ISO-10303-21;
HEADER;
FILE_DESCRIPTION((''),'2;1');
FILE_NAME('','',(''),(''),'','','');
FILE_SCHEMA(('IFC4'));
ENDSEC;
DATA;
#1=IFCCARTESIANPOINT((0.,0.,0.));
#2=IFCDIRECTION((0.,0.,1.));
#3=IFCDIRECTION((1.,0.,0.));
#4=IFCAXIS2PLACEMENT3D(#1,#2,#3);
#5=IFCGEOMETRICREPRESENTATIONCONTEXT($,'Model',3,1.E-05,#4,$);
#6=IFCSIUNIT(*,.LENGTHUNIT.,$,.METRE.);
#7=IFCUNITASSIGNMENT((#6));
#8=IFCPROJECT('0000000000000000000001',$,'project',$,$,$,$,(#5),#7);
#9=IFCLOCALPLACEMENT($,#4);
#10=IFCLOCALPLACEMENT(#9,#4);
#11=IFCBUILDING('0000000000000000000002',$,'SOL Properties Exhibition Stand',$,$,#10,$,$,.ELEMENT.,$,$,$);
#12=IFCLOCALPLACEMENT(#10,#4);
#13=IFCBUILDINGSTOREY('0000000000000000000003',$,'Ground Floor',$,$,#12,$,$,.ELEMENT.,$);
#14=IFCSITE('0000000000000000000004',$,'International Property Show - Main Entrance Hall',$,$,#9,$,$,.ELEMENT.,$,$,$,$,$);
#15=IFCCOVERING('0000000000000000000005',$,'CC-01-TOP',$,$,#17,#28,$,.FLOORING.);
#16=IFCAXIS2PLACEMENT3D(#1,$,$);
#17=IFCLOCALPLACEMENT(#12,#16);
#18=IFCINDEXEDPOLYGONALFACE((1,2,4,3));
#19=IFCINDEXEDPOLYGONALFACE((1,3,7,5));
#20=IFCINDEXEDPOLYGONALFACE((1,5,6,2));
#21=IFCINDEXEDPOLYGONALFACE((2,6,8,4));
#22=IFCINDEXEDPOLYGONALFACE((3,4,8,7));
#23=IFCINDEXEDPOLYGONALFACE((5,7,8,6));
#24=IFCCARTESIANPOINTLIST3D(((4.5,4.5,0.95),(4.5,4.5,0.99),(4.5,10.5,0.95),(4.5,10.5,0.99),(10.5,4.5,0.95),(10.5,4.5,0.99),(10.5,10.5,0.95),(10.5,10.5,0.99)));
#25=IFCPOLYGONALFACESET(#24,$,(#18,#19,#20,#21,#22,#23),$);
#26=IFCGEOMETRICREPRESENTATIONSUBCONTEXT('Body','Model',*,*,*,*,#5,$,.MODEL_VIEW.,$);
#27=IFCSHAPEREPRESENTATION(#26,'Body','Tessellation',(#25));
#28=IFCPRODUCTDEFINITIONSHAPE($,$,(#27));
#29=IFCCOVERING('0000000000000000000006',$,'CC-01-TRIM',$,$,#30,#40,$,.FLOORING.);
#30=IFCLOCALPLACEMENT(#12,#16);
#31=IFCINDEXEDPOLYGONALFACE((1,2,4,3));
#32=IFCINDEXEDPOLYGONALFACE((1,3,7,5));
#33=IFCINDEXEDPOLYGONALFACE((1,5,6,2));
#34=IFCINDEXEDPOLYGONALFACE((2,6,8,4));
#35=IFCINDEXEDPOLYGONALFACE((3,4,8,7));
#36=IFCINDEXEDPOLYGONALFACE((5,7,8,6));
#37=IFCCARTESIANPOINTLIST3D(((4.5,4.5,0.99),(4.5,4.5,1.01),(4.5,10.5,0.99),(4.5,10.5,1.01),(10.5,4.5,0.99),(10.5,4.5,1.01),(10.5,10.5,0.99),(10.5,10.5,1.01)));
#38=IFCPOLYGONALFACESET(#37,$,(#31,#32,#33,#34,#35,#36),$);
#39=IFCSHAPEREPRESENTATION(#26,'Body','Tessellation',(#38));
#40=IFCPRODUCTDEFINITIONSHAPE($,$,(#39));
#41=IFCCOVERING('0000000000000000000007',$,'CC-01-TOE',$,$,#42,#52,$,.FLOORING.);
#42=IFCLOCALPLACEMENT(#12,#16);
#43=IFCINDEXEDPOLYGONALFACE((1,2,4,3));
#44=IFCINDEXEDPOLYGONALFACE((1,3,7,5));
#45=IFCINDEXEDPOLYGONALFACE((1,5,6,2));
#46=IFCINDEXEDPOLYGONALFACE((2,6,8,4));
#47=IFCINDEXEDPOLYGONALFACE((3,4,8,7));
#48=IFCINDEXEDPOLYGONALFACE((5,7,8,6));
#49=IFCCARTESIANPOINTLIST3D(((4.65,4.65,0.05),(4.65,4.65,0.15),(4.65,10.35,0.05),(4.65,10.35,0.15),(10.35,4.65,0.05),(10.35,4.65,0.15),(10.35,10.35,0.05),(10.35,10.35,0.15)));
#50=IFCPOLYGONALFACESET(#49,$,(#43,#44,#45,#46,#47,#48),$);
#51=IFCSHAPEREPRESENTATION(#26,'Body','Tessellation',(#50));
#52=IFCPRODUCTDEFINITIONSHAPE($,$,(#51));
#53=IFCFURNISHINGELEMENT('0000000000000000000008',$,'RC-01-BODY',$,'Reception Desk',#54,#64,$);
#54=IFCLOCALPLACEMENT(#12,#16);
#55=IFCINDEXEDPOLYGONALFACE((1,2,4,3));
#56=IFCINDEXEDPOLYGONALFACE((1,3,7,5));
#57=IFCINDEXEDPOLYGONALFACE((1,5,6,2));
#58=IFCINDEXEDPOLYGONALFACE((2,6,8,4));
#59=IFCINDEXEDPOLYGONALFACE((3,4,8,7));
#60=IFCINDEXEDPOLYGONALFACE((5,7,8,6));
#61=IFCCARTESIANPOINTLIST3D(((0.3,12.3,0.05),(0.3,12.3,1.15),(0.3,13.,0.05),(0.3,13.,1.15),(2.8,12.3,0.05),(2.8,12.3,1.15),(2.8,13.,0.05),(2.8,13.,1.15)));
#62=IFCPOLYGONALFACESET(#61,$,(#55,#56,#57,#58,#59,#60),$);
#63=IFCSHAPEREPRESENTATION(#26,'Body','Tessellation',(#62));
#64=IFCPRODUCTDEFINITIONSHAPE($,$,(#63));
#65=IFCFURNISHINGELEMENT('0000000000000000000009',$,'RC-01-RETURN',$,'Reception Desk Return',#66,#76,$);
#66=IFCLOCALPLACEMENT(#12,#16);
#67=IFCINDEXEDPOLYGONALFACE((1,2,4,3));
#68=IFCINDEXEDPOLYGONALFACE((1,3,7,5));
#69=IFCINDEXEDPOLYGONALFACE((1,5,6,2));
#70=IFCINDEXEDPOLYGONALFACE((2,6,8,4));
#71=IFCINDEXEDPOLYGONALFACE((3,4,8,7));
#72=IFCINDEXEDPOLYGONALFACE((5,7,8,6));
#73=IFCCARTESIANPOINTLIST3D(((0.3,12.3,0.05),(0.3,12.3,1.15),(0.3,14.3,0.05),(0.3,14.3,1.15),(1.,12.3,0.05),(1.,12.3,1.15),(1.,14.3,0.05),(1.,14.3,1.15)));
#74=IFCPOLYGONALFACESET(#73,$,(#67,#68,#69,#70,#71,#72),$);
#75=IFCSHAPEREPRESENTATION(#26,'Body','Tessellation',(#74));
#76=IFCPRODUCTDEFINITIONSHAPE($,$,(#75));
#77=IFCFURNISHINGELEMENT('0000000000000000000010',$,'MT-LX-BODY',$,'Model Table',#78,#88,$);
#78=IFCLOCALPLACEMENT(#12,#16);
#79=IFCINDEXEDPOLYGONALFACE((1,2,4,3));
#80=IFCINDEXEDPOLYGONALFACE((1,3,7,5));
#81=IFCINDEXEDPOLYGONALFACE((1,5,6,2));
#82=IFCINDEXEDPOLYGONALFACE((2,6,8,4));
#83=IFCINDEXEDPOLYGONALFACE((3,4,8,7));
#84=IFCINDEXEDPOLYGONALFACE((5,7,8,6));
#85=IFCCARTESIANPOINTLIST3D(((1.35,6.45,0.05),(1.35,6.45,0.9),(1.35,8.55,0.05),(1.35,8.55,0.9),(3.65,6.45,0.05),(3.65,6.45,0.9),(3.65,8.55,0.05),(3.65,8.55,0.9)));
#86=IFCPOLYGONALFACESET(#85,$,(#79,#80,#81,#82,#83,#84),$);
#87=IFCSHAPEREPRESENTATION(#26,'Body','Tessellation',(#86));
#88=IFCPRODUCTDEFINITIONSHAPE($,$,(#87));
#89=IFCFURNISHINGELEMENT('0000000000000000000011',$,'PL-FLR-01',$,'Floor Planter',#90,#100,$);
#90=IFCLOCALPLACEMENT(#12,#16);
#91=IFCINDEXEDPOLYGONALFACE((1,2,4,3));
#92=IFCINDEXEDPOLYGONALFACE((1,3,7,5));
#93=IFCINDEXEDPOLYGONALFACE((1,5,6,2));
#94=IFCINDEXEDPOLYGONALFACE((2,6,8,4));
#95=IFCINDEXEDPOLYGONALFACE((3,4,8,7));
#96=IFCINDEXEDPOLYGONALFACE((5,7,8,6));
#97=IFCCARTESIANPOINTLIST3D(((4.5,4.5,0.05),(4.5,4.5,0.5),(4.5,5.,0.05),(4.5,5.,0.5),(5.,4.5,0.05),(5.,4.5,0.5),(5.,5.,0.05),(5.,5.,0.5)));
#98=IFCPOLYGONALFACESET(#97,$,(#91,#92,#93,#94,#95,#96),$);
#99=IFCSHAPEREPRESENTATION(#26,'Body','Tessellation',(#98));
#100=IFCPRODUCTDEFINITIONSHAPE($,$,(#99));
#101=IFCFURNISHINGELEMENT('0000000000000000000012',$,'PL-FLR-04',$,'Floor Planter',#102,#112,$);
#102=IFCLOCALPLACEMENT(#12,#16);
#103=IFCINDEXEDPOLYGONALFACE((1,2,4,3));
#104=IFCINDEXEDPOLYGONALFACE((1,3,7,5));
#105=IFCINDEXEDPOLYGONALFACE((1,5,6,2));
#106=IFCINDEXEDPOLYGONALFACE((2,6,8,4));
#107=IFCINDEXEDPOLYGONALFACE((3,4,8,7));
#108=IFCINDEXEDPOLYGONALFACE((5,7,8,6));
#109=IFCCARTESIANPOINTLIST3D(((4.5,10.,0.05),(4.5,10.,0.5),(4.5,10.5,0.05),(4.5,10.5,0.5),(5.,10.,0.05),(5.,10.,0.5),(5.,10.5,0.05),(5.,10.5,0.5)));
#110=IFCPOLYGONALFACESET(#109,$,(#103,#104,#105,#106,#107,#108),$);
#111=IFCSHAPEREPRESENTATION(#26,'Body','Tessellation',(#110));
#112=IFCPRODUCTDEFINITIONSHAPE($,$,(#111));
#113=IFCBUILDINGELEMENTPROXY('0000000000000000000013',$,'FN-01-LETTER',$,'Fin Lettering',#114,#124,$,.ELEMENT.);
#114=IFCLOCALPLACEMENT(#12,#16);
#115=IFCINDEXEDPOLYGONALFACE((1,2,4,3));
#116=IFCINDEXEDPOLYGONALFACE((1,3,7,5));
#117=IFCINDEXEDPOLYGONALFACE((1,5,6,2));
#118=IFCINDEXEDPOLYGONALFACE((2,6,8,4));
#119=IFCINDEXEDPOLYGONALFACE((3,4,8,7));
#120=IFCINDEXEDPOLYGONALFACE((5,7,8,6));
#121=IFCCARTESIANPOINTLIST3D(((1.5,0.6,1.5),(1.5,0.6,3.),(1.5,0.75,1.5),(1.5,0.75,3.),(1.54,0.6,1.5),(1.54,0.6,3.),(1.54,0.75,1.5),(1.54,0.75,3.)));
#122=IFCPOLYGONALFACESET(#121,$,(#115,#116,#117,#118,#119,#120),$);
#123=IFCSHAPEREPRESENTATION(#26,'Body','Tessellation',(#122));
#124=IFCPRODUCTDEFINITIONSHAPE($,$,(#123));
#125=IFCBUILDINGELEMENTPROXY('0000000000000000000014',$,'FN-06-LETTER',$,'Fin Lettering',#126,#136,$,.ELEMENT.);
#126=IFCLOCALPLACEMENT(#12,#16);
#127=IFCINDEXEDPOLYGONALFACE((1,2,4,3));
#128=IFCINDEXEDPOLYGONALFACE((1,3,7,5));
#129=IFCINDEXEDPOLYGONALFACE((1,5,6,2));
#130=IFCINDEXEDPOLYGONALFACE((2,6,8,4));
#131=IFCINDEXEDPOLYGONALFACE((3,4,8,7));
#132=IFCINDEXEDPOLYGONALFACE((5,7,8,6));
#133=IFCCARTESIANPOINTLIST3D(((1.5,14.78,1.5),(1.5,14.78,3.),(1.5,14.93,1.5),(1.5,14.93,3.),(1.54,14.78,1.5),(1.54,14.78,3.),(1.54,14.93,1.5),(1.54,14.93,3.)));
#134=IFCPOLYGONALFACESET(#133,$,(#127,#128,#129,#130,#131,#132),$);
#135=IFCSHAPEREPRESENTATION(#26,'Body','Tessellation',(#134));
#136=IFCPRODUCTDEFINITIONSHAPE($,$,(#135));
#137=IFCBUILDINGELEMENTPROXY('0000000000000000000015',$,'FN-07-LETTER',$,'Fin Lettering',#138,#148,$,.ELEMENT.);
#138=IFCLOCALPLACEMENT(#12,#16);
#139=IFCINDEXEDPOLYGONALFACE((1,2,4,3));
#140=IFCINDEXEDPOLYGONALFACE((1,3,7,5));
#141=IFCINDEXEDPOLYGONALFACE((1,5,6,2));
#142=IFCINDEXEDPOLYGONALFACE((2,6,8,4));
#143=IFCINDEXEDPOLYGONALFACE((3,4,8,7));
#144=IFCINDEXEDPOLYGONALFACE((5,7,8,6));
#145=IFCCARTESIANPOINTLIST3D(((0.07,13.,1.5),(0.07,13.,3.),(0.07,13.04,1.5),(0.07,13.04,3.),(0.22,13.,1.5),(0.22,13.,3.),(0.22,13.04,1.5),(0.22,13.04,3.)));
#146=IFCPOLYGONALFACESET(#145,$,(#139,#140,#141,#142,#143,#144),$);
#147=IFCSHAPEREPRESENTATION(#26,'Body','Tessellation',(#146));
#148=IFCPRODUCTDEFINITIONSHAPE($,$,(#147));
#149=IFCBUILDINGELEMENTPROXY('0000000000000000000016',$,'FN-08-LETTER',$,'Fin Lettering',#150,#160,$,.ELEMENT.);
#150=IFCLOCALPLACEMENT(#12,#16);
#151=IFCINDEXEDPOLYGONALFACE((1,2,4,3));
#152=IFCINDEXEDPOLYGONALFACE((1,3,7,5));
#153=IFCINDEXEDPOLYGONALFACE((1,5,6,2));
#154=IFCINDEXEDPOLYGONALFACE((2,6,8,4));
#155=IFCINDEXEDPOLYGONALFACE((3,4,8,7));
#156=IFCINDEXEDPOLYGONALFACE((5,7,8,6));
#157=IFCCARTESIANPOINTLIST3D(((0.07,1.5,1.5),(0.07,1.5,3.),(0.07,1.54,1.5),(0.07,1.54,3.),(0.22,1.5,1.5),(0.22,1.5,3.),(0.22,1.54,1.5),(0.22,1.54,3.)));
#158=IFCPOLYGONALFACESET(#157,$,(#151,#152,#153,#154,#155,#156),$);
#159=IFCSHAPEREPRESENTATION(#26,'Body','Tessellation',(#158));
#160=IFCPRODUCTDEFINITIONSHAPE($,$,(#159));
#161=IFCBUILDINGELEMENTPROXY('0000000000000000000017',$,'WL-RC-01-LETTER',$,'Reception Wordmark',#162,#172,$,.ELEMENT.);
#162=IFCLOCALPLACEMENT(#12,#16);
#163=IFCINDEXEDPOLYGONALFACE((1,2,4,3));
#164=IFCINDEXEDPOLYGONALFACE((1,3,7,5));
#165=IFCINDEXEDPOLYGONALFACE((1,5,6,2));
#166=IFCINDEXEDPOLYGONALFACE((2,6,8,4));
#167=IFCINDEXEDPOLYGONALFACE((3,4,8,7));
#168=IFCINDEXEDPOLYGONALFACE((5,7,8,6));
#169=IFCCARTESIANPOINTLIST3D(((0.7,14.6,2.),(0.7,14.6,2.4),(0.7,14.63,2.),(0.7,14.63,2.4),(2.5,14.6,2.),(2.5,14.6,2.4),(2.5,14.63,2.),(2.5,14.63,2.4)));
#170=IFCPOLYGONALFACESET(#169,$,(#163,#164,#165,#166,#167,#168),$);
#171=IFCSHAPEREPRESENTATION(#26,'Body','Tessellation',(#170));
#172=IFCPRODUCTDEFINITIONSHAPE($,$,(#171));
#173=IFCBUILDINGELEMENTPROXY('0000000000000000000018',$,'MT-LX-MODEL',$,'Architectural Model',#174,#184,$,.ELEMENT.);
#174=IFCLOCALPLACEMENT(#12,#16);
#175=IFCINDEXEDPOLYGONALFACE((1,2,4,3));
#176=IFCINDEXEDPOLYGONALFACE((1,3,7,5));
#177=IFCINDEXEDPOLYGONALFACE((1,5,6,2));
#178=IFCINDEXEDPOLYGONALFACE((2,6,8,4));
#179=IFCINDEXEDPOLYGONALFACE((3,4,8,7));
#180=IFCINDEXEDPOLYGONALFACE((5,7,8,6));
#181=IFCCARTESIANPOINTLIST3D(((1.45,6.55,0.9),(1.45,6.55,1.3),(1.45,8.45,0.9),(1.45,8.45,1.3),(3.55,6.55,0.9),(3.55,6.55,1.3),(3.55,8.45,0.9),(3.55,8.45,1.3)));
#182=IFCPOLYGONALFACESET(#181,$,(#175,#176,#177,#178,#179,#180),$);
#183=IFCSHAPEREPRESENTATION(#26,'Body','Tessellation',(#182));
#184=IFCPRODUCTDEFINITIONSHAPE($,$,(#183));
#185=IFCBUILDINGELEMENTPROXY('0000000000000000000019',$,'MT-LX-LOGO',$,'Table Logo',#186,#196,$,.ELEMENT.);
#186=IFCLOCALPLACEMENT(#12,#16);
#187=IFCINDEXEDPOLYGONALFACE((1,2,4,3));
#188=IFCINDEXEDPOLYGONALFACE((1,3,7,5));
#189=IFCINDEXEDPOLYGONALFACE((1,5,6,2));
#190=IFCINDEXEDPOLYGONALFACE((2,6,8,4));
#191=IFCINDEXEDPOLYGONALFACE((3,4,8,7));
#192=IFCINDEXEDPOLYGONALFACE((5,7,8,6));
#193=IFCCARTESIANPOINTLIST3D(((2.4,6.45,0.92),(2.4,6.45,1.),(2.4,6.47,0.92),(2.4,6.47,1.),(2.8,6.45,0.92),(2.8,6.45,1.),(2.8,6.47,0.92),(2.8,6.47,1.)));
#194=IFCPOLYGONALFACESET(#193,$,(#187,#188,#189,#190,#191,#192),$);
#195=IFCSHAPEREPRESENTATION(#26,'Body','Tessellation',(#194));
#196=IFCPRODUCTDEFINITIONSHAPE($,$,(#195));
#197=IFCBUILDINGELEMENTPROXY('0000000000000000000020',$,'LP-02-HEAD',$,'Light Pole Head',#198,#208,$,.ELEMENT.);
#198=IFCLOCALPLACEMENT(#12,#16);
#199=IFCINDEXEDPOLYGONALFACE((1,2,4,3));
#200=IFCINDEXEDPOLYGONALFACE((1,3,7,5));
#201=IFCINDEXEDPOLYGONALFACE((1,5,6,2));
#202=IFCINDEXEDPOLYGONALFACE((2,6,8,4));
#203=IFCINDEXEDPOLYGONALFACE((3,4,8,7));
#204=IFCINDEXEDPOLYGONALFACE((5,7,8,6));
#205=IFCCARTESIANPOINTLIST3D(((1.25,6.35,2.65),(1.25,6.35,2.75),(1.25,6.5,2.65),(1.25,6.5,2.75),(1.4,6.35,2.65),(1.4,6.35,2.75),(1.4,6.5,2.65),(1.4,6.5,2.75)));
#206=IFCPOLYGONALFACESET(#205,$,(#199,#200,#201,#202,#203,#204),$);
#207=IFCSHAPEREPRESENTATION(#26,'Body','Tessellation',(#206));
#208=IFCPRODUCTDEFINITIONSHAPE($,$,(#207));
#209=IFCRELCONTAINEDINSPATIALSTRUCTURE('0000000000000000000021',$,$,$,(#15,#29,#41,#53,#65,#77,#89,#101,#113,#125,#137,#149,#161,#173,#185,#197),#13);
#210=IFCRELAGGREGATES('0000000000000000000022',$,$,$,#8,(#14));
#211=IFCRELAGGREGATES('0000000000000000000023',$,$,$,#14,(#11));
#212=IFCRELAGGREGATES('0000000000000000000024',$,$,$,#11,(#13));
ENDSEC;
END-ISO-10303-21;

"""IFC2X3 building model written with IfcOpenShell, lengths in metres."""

from ifc_helpers import new_model, si_unit, frame, frame_2d, origin, origin_with_axes, place, context, subcontext, project, spatial, rectangle, extrude, element, save


model = new_model("IFC2X3")

# Units and contexts
model_context = context("Model", 3, precision=1e-05, world=origin_with_axes())
body_context = subcontext(model_context, "Body", "Model", "MODEL_VIEW")
ifc_project = project(units=[si_unit("LENGTHUNIT", "METRE")], contexts=[model_context])

# Site, building, storey
site_placement = place(None, origin_with_axes())
site = spatial("IfcSite", under=ifc_project, at=site_placement, Name="International Property Show - Main Entrance Hall", CompositionType="ELEMENT")
building_placement = place(site_placement, origin_with_axes())
building = spatial("IfcBuilding", under=site, at=building_placement, Name="SOL Properties Exhibition Stand", CompositionType="ELEMENT")
storey_placement = place(building_placement, origin_with_axes())
storey = spatial("IfcBuildingStorey", under=building, at=storey_placement, Name="Ground Floor", CompositionType="ELEMENT")

# Coverings
covering_1_placement = place(storey_placement, frame((4.5, 4.5, 0.95), z_axis=(0.0, 0.0, 1.0), x_axis=(1.0, 0.0, 0.0)))
element("IfcCovering", 1, at=covering_1_placement, inside=storey, Name="CC-01-TOP", PredefinedType="FLOORING", context=body_context, shape_type="SweptSolid", body=[
    extrude(rectangle(XDim=6.0, YDim=6.0, at=frame_2d((3.0, 3.0))), origin(), (0.0, 0.0, 1.0), 0.04),
])
covering_2_placement = place(storey_placement, frame((4.5, 4.5, 0.99), z_axis=(0.0, 0.0, 1.0), x_axis=(1.0, 0.0, 0.0)))
element("IfcCovering", 2, at=covering_2_placement, inside=storey, Name="CC-01-TRIM", PredefinedType="FLOORING", context=body_context, shape_type="SweptSolid", body=[
    extrude(rectangle(XDim=6.0, YDim=6.0, at=frame_2d((3.0, 3.0))), origin(), (0.0, 0.0, 1.0), 0.02),
])
covering_3_placement = place(storey_placement, frame((4.65, 4.65, 0.05), z_axis=(0.0, 0.0, 1.0), x_axis=(1.0, 0.0, 0.0)))
element("IfcCovering", 3, at=covering_3_placement, inside=storey, Name="CC-01-TOE", PredefinedType="FLOORING", context=body_context, shape_type="SweptSolid", body=[
    extrude(rectangle(XDim=5.7, YDim=5.7, at=frame_2d((2.85, 2.85))), origin(), (0.0, 0.0, 1.0), 0.1),
])

# Furnishing elements
furnishing_1_placement = place(storey_placement, frame((0.3, 12.3, 0.05), z_axis=(0.0, 0.0, 1.0), x_axis=(1.0, 0.0, 0.0)))
element("IfcFurnishingElement", 4, at=furnishing_1_placement, inside=storey, Name="RC-01-BODY", ObjectType="Reception Desk", context=body_context, shape_type="SweptSolid", body=[
    extrude(rectangle(XDim=2.5, YDim=0.7, at=frame_2d((1.25, 0.35))), origin(), (0.0, 0.0, 1.0), 1.1),
])
furnishing_2_placement = place(storey_placement, frame((0.3, 12.3, 0.05), z_axis=(0.0, 0.0, 1.0), x_axis=(1.0, 0.0, 0.0)))
element("IfcFurnishingElement", 5, at=furnishing_2_placement, inside=storey, Name="RC-01-RETURN", ObjectType="Reception Desk Return", context=body_context, shape_type="SweptSolid", body=[
    extrude(rectangle(XDim=0.7, YDim=2.0, at=frame_2d((0.35, 1.0))), origin(), (0.0, 0.0, 1.0), 1.1),
])
furnishing_3_placement = place(storey_placement, frame((1.35, 6.45, 0.05), z_axis=(0.0, 0.0, 1.0), x_axis=(1.0, 0.0, 0.0)))
element("IfcFurnishingElement", 6, at=furnishing_3_placement, inside=storey, Name="MT-LX-BODY", ObjectType="Model Table", context=body_context, shape_type="SweptSolid", body=[
    extrude(rectangle(XDim=2.3, YDim=2.1, at=frame_2d((1.15, 1.05))), origin(), (0.0, 0.0, 1.0), 0.85),
])
for number, where, z_axis, x_axis, name in (
    (7, (4.5, 4.5, 0.05), (0.0, 0.0, 1.0), (1.0, 0.0, 0.0), "PL-FLR-01"),
    (8, (4.5, 10.0, 0.05), (0.0, 0.0, 1.0), (1.0, 0.0, 0.0), "PL-FLR-04"),
):
    element("IfcFurnishingElement", number, at=place(storey_placement, frame(where, z_axis=z_axis, x_axis=x_axis)), inside=storey, Name=name, ObjectType="Floor Planter", context=body_context, shape_type="SweptSolid", body=[
        extrude(rectangle(XDim=0.5, YDim=0.5, at=frame_2d((0.25, 0.25))), origin(), (0.0, 0.0, 1.0), 0.45),
    ])

# Building element proxies
for number, where, z_axis, x_axis, name in (
    (9, (1.5, 0.6, 1.5), (0.0, 0.0, 1.0), (1.0, 0.0, 0.0), "FN-01-LETTER"),
    (10, (1.5, 14.78, 1.5), (0.0, 0.0, 1.0), (1.0, 0.0, 0.0), "FN-06-LETTER"),
):
    element("IfcBuildingElementProxy", number, at=place(storey_placement, frame(where, z_axis=z_axis, x_axis=x_axis)), inside=storey, Name=name, ObjectType="Fin Lettering", CompositionType="ELEMENT", context=body_context, shape_type="SweptSolid", body=[
        extrude(rectangle(XDim=0.04, YDim=0.15, at=frame_2d((0.02, 0.075))), origin(), (0.0, 0.0, 1.0), 1.5),
    ])
for number, where, z_axis, x_axis, name in (
    (11, (0.07, 13.0, 1.5), (0.0, 0.0, 1.0), (1.0, 0.0, 0.0), "FN-07-LETTER"),
    (12, (0.07, 1.5, 1.5), (0.0, 0.0, 1.0), (1.0, 0.0, 0.0), "FN-08-LETTER"),
):
    element("IfcBuildingElementProxy", number, at=place(storey_placement, frame(where, z_axis=z_axis, x_axis=x_axis)), inside=storey, Name=name, ObjectType="Fin Lettering", CompositionType="ELEMENT", context=body_context, shape_type="SweptSolid", body=[
        extrude(rectangle(XDim=0.15, YDim=0.04, at=frame_2d((0.075, 0.02))), origin(), (0.0, 0.0, 1.0), 1.5),
    ])
proxy_1_placement = place(storey_placement, frame((0.7, 14.6, 2.0), z_axis=(0.0, 0.0, 1.0), x_axis=(1.0, 0.0, 0.0)))
element("IfcBuildingElementProxy", 13, at=proxy_1_placement, inside=storey, Name="WL-RC-01-LETTER", ObjectType="Reception Wordmark", CompositionType="ELEMENT", context=body_context, shape_type="SweptSolid", body=[
    extrude(rectangle(XDim=1.8, YDim=0.03, at=frame_2d((0.9, 0.015))), origin(), (0.0, 0.0, 1.0), 0.4),
])
proxy_2_placement = place(storey_placement, frame((1.45, 6.55, 0.9), z_axis=(0.0, 0.0, 1.0), x_axis=(1.0, 0.0, 0.0)))
element("IfcBuildingElementProxy", 14, at=proxy_2_placement, inside=storey, Name="MT-LX-MODEL", ObjectType="Architectural Model", CompositionType="ELEMENT", context=body_context, shape_type="SweptSolid", body=[
    extrude(rectangle(XDim=2.1, YDim=1.9, at=frame_2d((1.05, 0.95))), origin(), (0.0, 0.0, 1.0), 0.4),
])
proxy_3_placement = place(storey_placement, frame((2.4, 6.45, 0.92), z_axis=(0.0, 0.0, 1.0), x_axis=(1.0, 0.0, 0.0)))
element("IfcBuildingElementProxy", 15, at=proxy_3_placement, inside=storey, Name="MT-LX-LOGO", ObjectType="Table Logo", CompositionType="ELEMENT", context=body_context, shape_type="SweptSolid", body=[
    extrude(rectangle(XDim=0.4, YDim=0.02, at=frame_2d((0.2, 0.01))), origin(), (0.0, 0.0, 1.0), 0.08),
])
for number, where, z_axis, x_axis, name in (
    (16, (1.25, 6.35, 2.65), (0.0, 0.0, 1.0), (1.0, 0.0, 0.0), "LP-02-HEAD"),
):
    element("IfcBuildingElementProxy", number, at=place(storey_placement, frame(where, z_axis=z_axis, x_axis=x_axis)), inside=storey, Name=name, ObjectType="Light Pole Head", CompositionType="ELEMENT", context=body_context, shape_type="SweptSolid", body=[
        extrude(rectangle(XDim=0.15, YDim=0.15, at=frame_2d((0.075, 0.075))), origin(), (0.0, 0.0, 1.0), 0.1),
    ])

save(model, "model.ifc")
